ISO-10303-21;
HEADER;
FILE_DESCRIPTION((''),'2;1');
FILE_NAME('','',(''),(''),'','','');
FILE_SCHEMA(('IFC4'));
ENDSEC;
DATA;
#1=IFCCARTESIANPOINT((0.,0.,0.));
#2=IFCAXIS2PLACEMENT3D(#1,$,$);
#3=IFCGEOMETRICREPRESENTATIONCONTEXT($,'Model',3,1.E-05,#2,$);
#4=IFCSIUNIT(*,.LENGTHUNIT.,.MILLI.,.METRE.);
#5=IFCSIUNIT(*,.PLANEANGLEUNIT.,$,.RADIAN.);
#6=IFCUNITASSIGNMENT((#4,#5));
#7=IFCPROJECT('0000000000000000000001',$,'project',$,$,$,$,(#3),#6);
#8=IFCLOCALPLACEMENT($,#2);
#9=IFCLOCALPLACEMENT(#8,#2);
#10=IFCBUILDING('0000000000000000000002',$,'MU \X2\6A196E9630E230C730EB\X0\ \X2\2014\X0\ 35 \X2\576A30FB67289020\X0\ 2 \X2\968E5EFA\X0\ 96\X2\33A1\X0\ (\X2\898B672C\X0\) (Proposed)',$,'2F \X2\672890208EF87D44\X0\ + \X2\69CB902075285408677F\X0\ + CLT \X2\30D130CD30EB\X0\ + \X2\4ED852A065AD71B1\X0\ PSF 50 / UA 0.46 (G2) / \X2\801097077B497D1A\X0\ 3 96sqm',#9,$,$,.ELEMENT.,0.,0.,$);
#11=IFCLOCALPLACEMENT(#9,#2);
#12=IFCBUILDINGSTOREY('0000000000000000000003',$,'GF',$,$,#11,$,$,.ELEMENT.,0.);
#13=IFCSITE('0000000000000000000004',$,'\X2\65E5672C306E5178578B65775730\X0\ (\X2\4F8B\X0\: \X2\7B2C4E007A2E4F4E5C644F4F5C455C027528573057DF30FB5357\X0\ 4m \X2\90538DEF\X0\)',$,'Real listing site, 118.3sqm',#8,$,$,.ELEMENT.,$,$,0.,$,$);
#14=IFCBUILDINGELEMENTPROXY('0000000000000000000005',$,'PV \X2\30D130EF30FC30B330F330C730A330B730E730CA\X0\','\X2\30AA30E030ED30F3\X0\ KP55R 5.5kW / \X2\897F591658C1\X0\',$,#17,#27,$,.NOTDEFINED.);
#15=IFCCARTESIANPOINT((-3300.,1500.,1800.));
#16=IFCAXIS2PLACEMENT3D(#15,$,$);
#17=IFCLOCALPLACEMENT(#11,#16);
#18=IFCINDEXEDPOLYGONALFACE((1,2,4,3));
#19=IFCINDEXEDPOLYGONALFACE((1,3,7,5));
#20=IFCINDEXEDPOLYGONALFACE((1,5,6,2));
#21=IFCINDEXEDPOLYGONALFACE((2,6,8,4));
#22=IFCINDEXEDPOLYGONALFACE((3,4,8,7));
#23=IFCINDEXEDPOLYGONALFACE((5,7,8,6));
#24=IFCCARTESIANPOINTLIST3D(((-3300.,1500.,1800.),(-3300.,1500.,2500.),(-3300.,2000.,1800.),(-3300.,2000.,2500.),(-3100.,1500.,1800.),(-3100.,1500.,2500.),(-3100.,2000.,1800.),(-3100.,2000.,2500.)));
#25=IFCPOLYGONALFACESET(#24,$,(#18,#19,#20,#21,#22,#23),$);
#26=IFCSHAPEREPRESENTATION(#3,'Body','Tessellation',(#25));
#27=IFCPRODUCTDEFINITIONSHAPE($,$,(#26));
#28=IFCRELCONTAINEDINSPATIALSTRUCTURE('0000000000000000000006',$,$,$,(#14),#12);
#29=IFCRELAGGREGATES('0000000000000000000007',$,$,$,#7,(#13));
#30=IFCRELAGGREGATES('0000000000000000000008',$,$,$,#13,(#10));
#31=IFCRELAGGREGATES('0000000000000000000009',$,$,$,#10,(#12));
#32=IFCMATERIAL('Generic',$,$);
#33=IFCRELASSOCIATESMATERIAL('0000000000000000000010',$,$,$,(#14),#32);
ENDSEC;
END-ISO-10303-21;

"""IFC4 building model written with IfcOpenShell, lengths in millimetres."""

from ifc_helpers import new_model, si_unit, frame, frame_2d, origin, place, context, project, spatial, rectangle, extrude, material, element, save


model = new_model("IFC4")

# Units and contexts
model_context = context("Model", 3, precision=1e-05, world=origin())
ifc_project = project(units=[si_unit("LENGTHUNIT", "METRE", prefix="MILLI"), si_unit("PLANEANGLEUNIT", "RADIAN")], contexts=[model_context])

# Site, building, storey
site_placement = place(None, origin())
site = spatial("IfcSite", under=ifc_project, at=site_placement, Name="日本の典型敷地 (例: 第一種低層住居専用地域・南 4m 道路)", ObjectType="Real listing site, 118.3sqm", CompositionType="ELEMENT", RefElevation=0.0)
building_placement = place(site_placement, origin())
building = spatial("IfcBuilding", under=site, at=building_placement, Name="MU 標準モデル — 35 坪・木造 2 階建 96㎡ (見本) (Proposed)", ObjectType="2F 木造軸組 + 構造用合板 + CLT パネル + 付加断熱 PSF 50 / UA 0.46 (G2) / 耐震等級 3 96sqm", CompositionType="ELEMENT", ElevationOfRefHeight=0.0, ElevationOfTerrain=0.0)
storey_placement = place(building_placement, origin())
storey = spatial("IfcBuildingStorey", under=building, at=storey_placement, Name="GF", CompositionType="ELEMENT", Elevation=0.0)

# Shared definitions
ifc_material_1 = material(Name="Generic")

# Building element proxy
proxy_1_placement = place(storey_placement, frame((-3300.0, 1500.0, 1800.0)))
element("IfcBuildingElementProxy", 1, at=proxy_1_placement, inside=storey, material=ifc_material_1, Name="PV パワーコンディショナ", Description="オムロン KP55R 5.5kW / 西外壁", PredefinedType="NOTDEFINED", context=model_context, shape_type="SweptSolid", body=[
    extrude(rectangle(XDim=200.0, YDim=500.0, at=frame_2d((100.0, 250.0))), frame((-3300.0, 1500.0, 1800.0)), (0.0, 0.0, 1.0), 700.0),
])

save(model, "model.ifc")
